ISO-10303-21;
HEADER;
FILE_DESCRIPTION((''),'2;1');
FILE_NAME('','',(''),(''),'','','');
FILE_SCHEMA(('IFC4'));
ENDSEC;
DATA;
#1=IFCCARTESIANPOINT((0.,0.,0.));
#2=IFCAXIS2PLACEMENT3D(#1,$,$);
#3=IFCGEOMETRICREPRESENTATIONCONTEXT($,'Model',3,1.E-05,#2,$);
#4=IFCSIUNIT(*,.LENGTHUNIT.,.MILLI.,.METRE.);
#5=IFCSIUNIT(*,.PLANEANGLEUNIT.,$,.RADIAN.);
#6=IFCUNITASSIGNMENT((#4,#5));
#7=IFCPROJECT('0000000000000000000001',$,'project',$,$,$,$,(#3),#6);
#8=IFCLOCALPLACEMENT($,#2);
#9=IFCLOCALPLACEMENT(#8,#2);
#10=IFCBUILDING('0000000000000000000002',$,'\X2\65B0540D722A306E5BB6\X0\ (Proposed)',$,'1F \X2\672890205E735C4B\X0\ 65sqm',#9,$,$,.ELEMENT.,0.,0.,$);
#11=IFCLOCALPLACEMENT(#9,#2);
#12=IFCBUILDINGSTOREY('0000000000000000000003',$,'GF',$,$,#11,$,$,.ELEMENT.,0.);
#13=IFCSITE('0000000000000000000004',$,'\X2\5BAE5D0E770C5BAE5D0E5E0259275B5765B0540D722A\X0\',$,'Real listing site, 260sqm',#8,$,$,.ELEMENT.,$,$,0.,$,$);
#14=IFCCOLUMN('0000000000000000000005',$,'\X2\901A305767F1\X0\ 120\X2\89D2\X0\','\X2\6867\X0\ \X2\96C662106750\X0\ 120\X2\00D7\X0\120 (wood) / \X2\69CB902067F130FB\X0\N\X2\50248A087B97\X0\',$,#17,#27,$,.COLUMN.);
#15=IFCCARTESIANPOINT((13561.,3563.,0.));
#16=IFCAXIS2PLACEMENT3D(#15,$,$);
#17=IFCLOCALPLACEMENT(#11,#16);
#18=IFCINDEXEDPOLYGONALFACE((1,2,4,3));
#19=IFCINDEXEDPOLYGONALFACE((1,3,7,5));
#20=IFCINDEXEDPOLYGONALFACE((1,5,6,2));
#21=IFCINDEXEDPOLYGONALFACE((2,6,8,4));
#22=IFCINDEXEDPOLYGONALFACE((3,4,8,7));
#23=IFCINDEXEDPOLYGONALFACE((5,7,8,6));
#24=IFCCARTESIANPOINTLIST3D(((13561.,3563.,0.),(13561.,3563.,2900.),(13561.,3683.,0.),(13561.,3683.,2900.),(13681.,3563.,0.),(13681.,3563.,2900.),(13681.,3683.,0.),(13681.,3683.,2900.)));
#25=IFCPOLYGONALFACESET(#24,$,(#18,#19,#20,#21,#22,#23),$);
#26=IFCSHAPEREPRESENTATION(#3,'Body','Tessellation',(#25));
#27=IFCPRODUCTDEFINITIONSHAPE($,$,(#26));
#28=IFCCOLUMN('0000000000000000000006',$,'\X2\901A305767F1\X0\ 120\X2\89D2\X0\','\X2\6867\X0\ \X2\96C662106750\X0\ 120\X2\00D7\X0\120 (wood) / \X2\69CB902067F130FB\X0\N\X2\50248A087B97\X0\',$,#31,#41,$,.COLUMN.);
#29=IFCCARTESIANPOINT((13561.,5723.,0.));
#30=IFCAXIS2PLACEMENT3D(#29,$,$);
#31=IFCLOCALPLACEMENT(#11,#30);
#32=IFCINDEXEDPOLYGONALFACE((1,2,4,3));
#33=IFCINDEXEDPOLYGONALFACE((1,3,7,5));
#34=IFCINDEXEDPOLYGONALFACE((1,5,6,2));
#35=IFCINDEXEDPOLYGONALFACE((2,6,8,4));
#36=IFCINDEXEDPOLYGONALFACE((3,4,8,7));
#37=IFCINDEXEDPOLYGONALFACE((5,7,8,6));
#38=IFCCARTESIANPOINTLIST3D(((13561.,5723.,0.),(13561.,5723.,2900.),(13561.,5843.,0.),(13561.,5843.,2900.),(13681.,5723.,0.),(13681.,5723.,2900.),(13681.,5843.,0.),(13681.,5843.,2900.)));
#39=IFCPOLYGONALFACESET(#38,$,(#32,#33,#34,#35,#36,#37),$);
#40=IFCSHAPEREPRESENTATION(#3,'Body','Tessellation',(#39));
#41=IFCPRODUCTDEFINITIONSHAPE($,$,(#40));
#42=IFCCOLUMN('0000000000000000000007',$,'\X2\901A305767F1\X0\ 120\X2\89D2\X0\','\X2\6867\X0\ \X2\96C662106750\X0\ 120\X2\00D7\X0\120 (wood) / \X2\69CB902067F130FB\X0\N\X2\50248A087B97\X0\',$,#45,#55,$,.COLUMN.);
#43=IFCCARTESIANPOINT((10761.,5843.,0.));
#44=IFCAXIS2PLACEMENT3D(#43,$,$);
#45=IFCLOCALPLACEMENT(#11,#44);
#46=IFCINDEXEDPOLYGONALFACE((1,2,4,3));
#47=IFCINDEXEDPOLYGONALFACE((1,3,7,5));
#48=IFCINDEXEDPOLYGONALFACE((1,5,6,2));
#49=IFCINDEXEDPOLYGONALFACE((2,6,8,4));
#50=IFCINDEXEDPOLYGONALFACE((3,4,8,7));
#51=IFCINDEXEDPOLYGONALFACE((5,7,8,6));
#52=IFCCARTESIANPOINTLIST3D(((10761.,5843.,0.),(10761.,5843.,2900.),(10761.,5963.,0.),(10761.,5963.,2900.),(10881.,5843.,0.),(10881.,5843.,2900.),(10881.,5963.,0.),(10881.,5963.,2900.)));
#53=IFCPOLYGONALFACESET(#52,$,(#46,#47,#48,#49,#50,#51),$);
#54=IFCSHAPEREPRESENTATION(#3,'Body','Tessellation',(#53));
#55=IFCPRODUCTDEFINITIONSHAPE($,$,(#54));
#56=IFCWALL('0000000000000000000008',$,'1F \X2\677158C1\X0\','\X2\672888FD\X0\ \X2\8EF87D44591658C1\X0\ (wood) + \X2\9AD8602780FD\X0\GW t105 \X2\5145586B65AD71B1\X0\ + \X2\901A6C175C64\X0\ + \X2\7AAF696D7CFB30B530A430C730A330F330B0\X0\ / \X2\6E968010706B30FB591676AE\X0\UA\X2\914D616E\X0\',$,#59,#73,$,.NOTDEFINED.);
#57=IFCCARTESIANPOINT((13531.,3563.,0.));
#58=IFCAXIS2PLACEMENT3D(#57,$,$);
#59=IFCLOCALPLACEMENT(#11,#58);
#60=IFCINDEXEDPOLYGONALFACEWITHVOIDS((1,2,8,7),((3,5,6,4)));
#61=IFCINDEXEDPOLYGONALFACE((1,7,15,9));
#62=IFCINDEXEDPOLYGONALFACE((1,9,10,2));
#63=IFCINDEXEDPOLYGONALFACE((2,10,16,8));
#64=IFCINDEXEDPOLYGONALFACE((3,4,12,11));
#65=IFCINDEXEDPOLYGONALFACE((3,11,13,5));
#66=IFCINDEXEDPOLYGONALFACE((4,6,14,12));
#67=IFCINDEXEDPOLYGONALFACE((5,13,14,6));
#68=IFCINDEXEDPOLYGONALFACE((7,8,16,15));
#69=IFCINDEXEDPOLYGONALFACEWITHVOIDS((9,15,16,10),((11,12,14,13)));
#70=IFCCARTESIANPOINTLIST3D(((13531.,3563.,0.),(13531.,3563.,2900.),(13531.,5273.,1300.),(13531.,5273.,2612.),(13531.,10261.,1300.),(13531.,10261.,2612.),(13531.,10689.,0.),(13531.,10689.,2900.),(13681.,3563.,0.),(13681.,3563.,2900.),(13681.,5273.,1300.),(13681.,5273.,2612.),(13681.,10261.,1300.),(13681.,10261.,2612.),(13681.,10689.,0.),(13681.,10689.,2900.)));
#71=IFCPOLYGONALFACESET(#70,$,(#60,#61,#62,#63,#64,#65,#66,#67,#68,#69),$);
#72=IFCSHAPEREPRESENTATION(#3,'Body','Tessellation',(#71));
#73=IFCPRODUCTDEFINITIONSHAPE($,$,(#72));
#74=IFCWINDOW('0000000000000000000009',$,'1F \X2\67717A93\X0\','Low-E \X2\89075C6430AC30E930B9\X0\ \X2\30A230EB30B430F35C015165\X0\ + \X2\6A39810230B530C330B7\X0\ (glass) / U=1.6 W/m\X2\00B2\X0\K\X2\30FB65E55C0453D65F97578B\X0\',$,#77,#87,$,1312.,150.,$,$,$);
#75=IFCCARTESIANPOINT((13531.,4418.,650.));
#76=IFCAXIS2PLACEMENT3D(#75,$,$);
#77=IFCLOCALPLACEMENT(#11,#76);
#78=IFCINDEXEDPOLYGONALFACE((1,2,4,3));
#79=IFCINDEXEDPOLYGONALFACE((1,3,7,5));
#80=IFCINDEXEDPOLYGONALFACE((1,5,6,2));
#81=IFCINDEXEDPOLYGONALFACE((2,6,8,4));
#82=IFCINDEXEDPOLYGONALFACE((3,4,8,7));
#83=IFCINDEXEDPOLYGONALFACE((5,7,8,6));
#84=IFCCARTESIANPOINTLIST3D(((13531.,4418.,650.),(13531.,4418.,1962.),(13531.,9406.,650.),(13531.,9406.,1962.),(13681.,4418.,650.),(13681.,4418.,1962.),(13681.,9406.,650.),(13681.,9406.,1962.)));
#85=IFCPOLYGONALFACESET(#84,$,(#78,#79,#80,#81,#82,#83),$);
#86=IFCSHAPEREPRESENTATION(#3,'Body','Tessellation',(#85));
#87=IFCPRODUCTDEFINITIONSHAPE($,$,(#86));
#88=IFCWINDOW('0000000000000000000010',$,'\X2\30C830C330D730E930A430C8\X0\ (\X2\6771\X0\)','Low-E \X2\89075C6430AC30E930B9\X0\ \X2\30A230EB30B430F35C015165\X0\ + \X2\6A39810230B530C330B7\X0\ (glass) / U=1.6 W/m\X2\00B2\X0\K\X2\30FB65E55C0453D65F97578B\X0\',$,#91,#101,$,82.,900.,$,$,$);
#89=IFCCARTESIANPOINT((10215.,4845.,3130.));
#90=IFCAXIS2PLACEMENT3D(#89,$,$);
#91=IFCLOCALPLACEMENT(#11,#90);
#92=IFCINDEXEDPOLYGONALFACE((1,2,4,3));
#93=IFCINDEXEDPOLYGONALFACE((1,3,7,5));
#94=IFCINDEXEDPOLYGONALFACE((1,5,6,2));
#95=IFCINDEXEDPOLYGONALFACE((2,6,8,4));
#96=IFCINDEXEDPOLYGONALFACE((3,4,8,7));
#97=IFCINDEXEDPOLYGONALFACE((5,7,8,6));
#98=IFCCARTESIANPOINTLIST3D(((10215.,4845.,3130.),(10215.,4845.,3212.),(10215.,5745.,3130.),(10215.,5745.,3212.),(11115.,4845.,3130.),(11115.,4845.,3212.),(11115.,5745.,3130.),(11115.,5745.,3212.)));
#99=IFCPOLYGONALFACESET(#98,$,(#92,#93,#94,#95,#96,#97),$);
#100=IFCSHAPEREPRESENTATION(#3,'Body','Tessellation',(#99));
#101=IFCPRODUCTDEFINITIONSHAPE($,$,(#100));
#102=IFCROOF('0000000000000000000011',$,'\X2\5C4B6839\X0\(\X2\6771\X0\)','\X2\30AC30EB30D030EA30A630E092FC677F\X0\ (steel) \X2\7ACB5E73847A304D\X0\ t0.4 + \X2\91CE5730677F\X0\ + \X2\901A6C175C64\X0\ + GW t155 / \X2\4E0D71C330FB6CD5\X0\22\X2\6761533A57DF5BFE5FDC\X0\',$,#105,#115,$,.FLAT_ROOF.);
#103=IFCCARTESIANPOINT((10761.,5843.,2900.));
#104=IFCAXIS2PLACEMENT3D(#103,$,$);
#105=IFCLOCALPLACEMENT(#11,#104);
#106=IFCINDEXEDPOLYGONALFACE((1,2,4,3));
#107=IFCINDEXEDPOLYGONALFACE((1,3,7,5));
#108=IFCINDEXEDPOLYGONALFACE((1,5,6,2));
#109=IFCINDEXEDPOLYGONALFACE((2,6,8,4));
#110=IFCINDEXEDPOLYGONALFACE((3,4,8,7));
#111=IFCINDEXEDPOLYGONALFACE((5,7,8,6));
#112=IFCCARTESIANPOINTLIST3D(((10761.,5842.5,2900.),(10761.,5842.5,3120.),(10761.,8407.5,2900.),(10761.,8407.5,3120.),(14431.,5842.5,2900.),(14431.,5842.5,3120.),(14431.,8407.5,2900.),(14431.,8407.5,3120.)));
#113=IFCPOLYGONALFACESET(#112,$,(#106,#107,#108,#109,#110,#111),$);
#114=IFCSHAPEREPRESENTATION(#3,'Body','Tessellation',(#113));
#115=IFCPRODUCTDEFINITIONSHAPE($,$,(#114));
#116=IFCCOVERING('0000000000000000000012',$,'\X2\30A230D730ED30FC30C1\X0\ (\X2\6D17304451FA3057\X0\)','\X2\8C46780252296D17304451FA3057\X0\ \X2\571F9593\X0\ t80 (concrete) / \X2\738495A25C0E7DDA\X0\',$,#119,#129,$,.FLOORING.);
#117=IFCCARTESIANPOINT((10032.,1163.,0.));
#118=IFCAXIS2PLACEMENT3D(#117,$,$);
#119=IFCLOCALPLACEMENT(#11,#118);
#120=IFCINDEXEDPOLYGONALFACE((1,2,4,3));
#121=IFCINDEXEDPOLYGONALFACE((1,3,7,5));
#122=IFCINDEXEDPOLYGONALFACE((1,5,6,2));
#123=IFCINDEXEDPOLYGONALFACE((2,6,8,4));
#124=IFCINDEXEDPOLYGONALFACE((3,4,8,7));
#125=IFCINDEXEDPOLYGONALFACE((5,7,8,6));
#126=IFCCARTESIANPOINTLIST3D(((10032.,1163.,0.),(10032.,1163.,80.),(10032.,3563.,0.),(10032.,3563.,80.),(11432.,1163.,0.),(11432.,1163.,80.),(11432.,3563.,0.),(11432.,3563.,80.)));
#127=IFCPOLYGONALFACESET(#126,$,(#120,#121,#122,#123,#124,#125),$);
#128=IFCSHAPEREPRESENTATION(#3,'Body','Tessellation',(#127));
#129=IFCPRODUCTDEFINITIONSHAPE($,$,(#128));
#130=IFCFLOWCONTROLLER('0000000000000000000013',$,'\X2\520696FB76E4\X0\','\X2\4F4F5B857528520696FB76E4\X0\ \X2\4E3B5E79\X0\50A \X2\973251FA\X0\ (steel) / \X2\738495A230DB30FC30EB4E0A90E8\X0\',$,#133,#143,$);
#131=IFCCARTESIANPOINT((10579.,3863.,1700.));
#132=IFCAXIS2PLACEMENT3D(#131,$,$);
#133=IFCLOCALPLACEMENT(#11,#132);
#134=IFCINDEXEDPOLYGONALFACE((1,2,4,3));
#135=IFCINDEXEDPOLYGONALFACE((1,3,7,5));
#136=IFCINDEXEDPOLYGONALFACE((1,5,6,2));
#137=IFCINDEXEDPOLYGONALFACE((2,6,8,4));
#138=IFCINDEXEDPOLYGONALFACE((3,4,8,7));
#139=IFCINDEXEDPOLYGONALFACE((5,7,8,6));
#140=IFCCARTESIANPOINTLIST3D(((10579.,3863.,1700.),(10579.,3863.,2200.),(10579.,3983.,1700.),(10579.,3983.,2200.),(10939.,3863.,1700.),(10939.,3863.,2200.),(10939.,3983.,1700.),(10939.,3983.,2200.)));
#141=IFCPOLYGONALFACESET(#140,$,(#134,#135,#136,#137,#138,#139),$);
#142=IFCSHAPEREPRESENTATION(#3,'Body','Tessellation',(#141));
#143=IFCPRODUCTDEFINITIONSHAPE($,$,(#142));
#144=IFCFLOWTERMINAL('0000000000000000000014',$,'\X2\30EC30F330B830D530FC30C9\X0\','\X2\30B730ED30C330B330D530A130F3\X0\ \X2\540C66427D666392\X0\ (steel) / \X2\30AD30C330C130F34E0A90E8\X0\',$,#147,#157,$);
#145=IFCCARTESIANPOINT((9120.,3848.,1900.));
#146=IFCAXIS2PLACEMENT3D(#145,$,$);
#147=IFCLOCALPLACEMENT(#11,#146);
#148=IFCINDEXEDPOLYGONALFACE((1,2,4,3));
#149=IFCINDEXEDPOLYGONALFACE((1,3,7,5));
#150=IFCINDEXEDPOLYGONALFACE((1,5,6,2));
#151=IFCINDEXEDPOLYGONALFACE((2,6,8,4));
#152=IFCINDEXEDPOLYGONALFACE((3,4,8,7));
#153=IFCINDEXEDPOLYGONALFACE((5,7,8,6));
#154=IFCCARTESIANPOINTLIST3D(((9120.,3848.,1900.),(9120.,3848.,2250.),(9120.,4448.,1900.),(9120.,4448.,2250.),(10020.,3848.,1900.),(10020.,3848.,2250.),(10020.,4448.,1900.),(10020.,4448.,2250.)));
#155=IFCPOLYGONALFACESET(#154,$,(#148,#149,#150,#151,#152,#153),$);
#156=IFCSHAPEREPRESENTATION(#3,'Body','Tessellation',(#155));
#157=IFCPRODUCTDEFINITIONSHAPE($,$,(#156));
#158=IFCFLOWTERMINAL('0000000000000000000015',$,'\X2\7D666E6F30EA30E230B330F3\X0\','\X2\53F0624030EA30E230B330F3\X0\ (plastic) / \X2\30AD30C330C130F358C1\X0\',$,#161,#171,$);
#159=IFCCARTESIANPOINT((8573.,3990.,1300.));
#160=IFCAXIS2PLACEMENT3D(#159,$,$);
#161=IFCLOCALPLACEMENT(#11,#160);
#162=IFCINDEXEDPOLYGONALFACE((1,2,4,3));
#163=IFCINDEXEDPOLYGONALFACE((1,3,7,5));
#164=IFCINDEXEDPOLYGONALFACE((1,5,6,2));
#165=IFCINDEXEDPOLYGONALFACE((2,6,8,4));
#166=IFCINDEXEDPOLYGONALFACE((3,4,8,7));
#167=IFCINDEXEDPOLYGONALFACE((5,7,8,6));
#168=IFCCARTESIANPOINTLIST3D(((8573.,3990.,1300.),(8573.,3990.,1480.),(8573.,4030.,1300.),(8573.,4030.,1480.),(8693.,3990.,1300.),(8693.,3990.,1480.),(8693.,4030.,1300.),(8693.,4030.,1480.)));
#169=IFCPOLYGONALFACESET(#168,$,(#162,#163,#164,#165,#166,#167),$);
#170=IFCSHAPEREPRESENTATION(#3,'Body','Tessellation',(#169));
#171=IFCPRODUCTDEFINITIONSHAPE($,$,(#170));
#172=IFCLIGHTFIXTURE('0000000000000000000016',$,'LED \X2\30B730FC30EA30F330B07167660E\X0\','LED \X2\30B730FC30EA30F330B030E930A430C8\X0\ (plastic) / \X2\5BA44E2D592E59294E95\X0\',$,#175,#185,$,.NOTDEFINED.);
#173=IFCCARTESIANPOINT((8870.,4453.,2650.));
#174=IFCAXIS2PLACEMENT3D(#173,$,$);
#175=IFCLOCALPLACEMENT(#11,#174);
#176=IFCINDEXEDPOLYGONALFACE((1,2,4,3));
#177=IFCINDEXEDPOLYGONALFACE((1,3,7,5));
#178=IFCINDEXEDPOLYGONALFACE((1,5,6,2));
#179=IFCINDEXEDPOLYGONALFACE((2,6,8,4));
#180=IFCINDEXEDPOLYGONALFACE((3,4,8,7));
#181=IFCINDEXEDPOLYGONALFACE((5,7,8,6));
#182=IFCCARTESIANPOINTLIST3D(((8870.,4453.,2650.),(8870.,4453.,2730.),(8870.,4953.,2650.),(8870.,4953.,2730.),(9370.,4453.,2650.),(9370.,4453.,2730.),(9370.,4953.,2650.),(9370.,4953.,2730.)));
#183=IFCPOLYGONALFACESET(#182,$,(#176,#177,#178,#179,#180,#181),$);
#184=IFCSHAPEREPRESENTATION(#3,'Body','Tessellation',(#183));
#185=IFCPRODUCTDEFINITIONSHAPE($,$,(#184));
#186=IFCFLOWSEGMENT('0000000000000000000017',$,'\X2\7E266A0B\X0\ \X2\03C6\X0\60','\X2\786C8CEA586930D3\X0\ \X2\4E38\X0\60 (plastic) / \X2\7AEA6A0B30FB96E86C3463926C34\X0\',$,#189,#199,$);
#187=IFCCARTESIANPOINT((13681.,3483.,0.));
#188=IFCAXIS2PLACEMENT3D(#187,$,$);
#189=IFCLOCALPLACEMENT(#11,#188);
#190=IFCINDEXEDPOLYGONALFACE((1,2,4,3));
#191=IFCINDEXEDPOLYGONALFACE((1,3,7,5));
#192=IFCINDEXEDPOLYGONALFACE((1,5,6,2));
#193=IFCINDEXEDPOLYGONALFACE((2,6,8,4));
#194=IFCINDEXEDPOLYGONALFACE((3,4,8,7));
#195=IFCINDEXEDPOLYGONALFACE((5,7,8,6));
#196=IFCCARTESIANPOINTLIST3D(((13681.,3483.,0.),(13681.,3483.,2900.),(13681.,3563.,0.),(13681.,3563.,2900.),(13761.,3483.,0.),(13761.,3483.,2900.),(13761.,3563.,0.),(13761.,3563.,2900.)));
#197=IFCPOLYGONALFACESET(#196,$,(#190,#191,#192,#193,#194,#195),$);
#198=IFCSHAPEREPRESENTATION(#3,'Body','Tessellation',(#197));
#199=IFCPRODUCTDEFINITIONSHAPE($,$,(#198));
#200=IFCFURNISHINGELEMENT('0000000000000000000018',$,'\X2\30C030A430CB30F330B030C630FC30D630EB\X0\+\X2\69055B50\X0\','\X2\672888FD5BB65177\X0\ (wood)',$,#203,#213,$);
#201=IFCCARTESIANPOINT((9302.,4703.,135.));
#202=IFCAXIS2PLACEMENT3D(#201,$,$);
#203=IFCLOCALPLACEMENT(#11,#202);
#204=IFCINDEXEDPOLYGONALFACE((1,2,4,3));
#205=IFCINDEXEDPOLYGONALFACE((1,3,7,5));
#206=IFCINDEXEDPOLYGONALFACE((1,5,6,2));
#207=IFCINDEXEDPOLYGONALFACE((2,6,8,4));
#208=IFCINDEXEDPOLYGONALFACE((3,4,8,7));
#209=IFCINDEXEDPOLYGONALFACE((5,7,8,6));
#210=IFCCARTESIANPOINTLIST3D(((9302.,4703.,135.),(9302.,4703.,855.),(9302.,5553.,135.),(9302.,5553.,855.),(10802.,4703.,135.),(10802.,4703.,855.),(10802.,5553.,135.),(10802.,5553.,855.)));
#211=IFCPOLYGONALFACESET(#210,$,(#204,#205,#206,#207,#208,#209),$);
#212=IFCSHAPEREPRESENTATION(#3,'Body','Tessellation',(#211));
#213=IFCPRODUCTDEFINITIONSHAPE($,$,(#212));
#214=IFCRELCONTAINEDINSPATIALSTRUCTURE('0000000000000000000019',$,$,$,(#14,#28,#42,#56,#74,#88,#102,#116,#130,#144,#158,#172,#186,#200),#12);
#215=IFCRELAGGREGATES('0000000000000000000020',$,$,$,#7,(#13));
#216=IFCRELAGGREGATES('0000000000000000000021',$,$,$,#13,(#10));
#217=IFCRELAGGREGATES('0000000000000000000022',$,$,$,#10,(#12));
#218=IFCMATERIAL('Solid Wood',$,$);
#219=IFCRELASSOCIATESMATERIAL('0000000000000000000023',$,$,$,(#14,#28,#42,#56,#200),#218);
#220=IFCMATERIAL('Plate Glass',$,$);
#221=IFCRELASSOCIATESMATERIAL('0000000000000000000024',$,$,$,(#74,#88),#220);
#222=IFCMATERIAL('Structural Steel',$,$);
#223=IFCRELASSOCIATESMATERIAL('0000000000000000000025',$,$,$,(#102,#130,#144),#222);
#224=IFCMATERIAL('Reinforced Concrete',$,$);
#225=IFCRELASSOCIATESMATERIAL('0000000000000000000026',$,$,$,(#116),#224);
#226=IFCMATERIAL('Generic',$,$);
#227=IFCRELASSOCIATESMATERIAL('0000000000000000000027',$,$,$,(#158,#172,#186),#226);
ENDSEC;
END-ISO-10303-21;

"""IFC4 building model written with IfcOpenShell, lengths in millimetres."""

from ifc_helpers import new_model, si_unit, frame, frame_2d, origin, place, context, project, spatial, rectangle, extrude, material, element, fill, save


model = new_model("IFC4")

# Units and contexts
model_context = context("Model", 3, precision=1e-05, world=origin())
ifc_project = project(units=[si_unit("LENGTHUNIT", "METRE", prefix="MILLI"), si_unit("PLANEANGLEUNIT", "RADIAN")], contexts=[model_context])

# Site, building, storey
site_placement = place(None, origin())
site = spatial("IfcSite", under=ifc_project, at=site_placement, Name="宮崎県宮崎市大字新名爪", ObjectType="Real listing site, 260sqm", CompositionType="ELEMENT", RefElevation=0.0)
building_placement = place(site_placement, origin())
building = spatial("IfcBuilding", under=site, at=building_placement, Name="新名爪の家 (Proposed)", ObjectType="1F 木造平屋 65sqm", CompositionType="ELEMENT", ElevationOfRefHeight=0.0, ElevationOfTerrain=0.0)
storey_placement = place(building_placement, origin())
storey = spatial("IfcBuildingStorey", under=building, at=storey_placement, Name="GF", CompositionType="ELEMENT", Elevation=0.0)

# Columns
ifc_material_1 = material(Name="Solid Wood")
column_1_placement = place(storey_placement, frame((13561.0, 3563.0, 0.0)))
element("IfcColumn", 1, at=column_1_placement, inside=storey, material=ifc_material_1, Name="通し柱 120角", Description="桧 集成材 120×120 (wood) / 構造柱・N値計算", PredefinedType="COLUMN", context=model_context, shape_type="SweptSolid", body=[
    extrude(rectangle(XDim=120.0, YDim=120.0, at=frame_2d((60.0, 60.0))), frame((13561.0, 3563.0, 0.0)), (0.0, 0.0, 1.0), 2900.0),
])
column_2_placement = place(storey_placement, frame((13561.0, 5723.0, 0.0)))
element("IfcColumn", 2, at=column_2_placement, inside=storey, material=ifc_material_1, Name="通し柱 120角", Description="桧 集成材 120×120 (wood) / 構造柱・N値計算", PredefinedType="COLUMN", context=model_context, shape_type="SweptSolid", body=[
    extrude(rectangle(XDim=120.0, YDim=120.0, at=frame_2d((60.0, 60.0))), frame((13561.0, 5723.0, 0.0)), (0.0, 0.0, 1.0), 2900.0),
])
column_3_placement = place(storey_placement, frame((10761.0, 5843.0, 0.0)))
element("IfcColumn", 3, at=column_3_placement, inside=storey, material=ifc_material_1, Name="通し柱 120角", Description="桧 集成材 120×120 (wood) / 構造柱・N値計算", PredefinedType="COLUMN", context=model_context, shape_type="SweptSolid", body=[
    extrude(rectangle(XDim=120.0, YDim=120.0, at=frame_2d((60.0, 60.0))), frame((10761.0, 5843.0, 0.0)), (0.0, 0.0, 1.0), 2900.0),
])

# Wall, opening, window
wall_1_placement = place(storey_placement, frame((13531.0, 3563.0, 0.0)))
wall_1 = element("IfcWall", 4, at=wall_1_placement, inside=storey, material=ifc_material_1, Name="1F 東壁", Description="木製 軸組外壁 (wood) + 高性能GW t105 充填断熱 + 通気層 + 窯業系サイディング / 準耐火・外皮UA配慮", PredefinedType="NOTDEFINED", context=model_context, shape_type="SweptSolid", body=[
    extrude(rectangle(XDim=150.0, YDim=7126.0, at=frame_2d((75.0, 3563.0))), frame((13531.0, 3563.0, 0.0)), (0.0, 0.0, 1.0), 2900.0),
])
opening_1_placement = place(storey_placement, frame((13531.0, 4418.0, 650.0)))
opening_1 = element("IfcOpeningElement", 5, at=opening_1_placement, cuts=wall_1, PredefinedType="NOTDEFINED", context=model_context, shape_type="SweptSolid", body=[
    extrude(rectangle(XDim=150.0, YDim=4988.0, at=frame_2d((75.0, 2494.0))), frame((13531.0, 4418.0, 650.0)), (0.0, 0.0, 1.0), 1312.0),
])
ifc_material_2 = material(Name="Plate Glass")
window_1_placement = place(storey_placement, frame((13531.0, 4418.0, 650.0)))
window_1 = element("IfcWindow", 6, at=window_1_placement, inside=storey, material=ifc_material_2, Name="1F 東窓", Description="Low-E 複層ガラス アルゴン封入 + 樹脂サッシ (glass) / U=1.6 W/m²K・日射取得型", OverallHeight=1312.0, OverallWidth=150.0, context=model_context, shape_type="SweptSolid", body=[
    extrude(rectangle(XDim=150.0, YDim=4988.0, at=frame_2d((75.0, 2494.0))), frame((13531.0, 4418.0, 650.0)), (0.0, 0.0, 1.0), 1312.0),
])
fill(opening_1, window_1)

# Window
window_2_placement = place(storey_placement, frame((10215.0, 4845.0, 3130.0)))
element("IfcWindow", 7, at=window_2_placement, inside=storey, material=ifc_material_2, Name="トップライト (東)", Description="Low-E 複層ガラス アルゴン封入 + 樹脂サッシ (glass) / U=1.6 W/m²K・日射取得型", OverallHeight=82.0, OverallWidth=900.0, context=model_context, shape_type="SweptSolid", body=[
    extrude(rectangle(XDim=900.0, YDim=900.0, at=frame_2d((450.0, 450.0))), frame((10215.0, 4845.0, 3130.0)), (0.0, 0.0, 1.0), 82.0),
])

# Roof
ifc_material_3 = material(Name="Structural Steel")
roof_placement = place(storey_placement, frame((10761.0, 5843.0, 2900.0)))
element("IfcRoof", 8, at=roof_placement, inside=storey, material=ifc_material_3, Name="屋根(東)", Description="ガルバリウム鋼板 (steel) 立平葺き t0.4 + 野地板 + 通気層 + GW t155 / 不燃・法22条区域対応", PredefinedType="FLAT_ROOF", context=model_context, shape_type="SweptSolid", body=[
    extrude(rectangle(XDim=3670.0, YDim=2565.0, at=frame_2d((1835.0, 1282.0))), frame((10761.0, 5843.0, 2900.0)), (0.0, 0.0, 1.0), 220.0),
])

# Covering
ifc_material_4 = material(Name="Reinforced Concrete")
covering_placement = place(storey_placement, frame((10032.0, 1163.0, 0.0)))
element("IfcCovering", 9, at=covering_placement, inside=storey, material=ifc_material_4, Name="アプローチ (洗い出し)", Description="豆砂利洗い出し 土間 t80 (concrete) / 玄関導線", PredefinedType="FLOORING", context=model_context, shape_type="SweptSolid", body=[
    extrude(rectangle(XDim=1400.0, YDim=2400.0, at=frame_2d((700.0, 1200.0))), frame((10032.0, 1163.0, 0.0)), (0.0, 0.0, 1.0), 80.0),
])

# Flow controller
flow_controller_placement = place(storey_placement, frame((10579.0, 3863.0, 1700.0)))
element("IfcFlowController", 10, at=flow_controller_placement, inside=storey, material=ifc_material_3, Name="分電盤", Description="住宅用分電盤 主幹50A 露出 (steel) / 玄関ホール上部", context=model_context, shape_type="SweptSolid", body=[
    extrude(rectangle(XDim=360.0, YDim=120.0, at=frame_2d((180.0, 60.0))), frame((10579.0, 3863.0, 1700.0)), (0.0, 0.0, 1.0), 500.0),
])

# Flow terminals
flow_terminal_1_placement = place(storey_placement, frame((9120.0, 3848.0, 1900.0)))
element("IfcFlowTerminal", 11, at=flow_terminal_1_placement, inside=storey, material=ifc_material_3, Name="レンジフード", Description="シロッコファン 同時給排 (steel) / キッチン上部", context=model_context, shape_type="SweptSolid", body=[
    extrude(rectangle(XDim=900.0, YDim=600.0, at=frame_2d((450.0, 300.0))), frame((9120.0, 3848.0, 1900.0)), (0.0, 0.0, 1.0), 350.0),
])
ifc_material_5 = material(Name="Generic")
flow_terminal_2_placement = place(storey_placement, frame((8573.0, 3990.0, 1300.0)))
element("IfcFlowTerminal", 12, at=flow_terminal_2_placement, inside=storey, material=ifc_material_5, Name="給湯リモコン", Description="台所リモコン (plastic) / キッチン壁", context=model_context, shape_type="SweptSolid", body=[
    extrude(rectangle(XDim=120.0, YDim=40.0, at=frame_2d((60.0, 20.0))), frame((8573.0, 3990.0, 1300.0)), (0.0, 0.0, 1.0), 180.0),
])

# Light fixture
light_fixture_placement = place(storey_placement, frame((8870.0, 4453.0, 2650.0)))
element("IfcLightFixture", 13, at=light_fixture_placement, inside=storey, material=ifc_material_5, Name="LED シーリング照明", Description="LED シーリングライト (plastic) / 室中央天井", PredefinedType="NOTDEFINED", context=model_context, shape_type="SweptSolid", body=[
    extrude(rectangle(XDim=500.0, YDim=500.0, at=frame_2d((250.0, 250.0))), frame((8870.0, 4453.0, 2650.0)), (0.0, 0.0, 1.0), 80.0),
])

# Flow segment
flow_segment_placement = place(storey_placement, frame((13681.0, 3483.0, 0.0)))
element("IfcFlowSegment", 14, at=flow_segment_placement, inside=storey, material=ifc_material_5, Name="縦樋 φ60", Description="硬質塩ビ 丸60 (plastic) / 竪樋・雨水排水", context=model_context, shape_type="SweptSolid", body=[
    extrude(rectangle(XDim=80.0, YDim=80.0, at=frame_2d((40.0, 40.0))), frame((13681.0, 3483.0, 0.0)), (0.0, 0.0, 1.0), 2900.0),
])

# Furnishing element
furnishing_1_placement = place(storey_placement, frame((9302.0, 4703.0, 135.0)))
element("IfcFurnishingElement", 15, at=furnishing_1_placement, inside=storey, material=ifc_material_1, Name="ダイニングテーブル+椅子", Description="木製家具 (wood)", context=model_context, shape_type="SweptSolid", body=[
    extrude(rectangle(XDim=1500.0, YDim=850.0, at=frame_2d((750.0, 425.0))), frame((9302.0, 4703.0, 135.0)), (0.0, 0.0, 1.0), 720.0),
])

save(model, "model.ifc")
